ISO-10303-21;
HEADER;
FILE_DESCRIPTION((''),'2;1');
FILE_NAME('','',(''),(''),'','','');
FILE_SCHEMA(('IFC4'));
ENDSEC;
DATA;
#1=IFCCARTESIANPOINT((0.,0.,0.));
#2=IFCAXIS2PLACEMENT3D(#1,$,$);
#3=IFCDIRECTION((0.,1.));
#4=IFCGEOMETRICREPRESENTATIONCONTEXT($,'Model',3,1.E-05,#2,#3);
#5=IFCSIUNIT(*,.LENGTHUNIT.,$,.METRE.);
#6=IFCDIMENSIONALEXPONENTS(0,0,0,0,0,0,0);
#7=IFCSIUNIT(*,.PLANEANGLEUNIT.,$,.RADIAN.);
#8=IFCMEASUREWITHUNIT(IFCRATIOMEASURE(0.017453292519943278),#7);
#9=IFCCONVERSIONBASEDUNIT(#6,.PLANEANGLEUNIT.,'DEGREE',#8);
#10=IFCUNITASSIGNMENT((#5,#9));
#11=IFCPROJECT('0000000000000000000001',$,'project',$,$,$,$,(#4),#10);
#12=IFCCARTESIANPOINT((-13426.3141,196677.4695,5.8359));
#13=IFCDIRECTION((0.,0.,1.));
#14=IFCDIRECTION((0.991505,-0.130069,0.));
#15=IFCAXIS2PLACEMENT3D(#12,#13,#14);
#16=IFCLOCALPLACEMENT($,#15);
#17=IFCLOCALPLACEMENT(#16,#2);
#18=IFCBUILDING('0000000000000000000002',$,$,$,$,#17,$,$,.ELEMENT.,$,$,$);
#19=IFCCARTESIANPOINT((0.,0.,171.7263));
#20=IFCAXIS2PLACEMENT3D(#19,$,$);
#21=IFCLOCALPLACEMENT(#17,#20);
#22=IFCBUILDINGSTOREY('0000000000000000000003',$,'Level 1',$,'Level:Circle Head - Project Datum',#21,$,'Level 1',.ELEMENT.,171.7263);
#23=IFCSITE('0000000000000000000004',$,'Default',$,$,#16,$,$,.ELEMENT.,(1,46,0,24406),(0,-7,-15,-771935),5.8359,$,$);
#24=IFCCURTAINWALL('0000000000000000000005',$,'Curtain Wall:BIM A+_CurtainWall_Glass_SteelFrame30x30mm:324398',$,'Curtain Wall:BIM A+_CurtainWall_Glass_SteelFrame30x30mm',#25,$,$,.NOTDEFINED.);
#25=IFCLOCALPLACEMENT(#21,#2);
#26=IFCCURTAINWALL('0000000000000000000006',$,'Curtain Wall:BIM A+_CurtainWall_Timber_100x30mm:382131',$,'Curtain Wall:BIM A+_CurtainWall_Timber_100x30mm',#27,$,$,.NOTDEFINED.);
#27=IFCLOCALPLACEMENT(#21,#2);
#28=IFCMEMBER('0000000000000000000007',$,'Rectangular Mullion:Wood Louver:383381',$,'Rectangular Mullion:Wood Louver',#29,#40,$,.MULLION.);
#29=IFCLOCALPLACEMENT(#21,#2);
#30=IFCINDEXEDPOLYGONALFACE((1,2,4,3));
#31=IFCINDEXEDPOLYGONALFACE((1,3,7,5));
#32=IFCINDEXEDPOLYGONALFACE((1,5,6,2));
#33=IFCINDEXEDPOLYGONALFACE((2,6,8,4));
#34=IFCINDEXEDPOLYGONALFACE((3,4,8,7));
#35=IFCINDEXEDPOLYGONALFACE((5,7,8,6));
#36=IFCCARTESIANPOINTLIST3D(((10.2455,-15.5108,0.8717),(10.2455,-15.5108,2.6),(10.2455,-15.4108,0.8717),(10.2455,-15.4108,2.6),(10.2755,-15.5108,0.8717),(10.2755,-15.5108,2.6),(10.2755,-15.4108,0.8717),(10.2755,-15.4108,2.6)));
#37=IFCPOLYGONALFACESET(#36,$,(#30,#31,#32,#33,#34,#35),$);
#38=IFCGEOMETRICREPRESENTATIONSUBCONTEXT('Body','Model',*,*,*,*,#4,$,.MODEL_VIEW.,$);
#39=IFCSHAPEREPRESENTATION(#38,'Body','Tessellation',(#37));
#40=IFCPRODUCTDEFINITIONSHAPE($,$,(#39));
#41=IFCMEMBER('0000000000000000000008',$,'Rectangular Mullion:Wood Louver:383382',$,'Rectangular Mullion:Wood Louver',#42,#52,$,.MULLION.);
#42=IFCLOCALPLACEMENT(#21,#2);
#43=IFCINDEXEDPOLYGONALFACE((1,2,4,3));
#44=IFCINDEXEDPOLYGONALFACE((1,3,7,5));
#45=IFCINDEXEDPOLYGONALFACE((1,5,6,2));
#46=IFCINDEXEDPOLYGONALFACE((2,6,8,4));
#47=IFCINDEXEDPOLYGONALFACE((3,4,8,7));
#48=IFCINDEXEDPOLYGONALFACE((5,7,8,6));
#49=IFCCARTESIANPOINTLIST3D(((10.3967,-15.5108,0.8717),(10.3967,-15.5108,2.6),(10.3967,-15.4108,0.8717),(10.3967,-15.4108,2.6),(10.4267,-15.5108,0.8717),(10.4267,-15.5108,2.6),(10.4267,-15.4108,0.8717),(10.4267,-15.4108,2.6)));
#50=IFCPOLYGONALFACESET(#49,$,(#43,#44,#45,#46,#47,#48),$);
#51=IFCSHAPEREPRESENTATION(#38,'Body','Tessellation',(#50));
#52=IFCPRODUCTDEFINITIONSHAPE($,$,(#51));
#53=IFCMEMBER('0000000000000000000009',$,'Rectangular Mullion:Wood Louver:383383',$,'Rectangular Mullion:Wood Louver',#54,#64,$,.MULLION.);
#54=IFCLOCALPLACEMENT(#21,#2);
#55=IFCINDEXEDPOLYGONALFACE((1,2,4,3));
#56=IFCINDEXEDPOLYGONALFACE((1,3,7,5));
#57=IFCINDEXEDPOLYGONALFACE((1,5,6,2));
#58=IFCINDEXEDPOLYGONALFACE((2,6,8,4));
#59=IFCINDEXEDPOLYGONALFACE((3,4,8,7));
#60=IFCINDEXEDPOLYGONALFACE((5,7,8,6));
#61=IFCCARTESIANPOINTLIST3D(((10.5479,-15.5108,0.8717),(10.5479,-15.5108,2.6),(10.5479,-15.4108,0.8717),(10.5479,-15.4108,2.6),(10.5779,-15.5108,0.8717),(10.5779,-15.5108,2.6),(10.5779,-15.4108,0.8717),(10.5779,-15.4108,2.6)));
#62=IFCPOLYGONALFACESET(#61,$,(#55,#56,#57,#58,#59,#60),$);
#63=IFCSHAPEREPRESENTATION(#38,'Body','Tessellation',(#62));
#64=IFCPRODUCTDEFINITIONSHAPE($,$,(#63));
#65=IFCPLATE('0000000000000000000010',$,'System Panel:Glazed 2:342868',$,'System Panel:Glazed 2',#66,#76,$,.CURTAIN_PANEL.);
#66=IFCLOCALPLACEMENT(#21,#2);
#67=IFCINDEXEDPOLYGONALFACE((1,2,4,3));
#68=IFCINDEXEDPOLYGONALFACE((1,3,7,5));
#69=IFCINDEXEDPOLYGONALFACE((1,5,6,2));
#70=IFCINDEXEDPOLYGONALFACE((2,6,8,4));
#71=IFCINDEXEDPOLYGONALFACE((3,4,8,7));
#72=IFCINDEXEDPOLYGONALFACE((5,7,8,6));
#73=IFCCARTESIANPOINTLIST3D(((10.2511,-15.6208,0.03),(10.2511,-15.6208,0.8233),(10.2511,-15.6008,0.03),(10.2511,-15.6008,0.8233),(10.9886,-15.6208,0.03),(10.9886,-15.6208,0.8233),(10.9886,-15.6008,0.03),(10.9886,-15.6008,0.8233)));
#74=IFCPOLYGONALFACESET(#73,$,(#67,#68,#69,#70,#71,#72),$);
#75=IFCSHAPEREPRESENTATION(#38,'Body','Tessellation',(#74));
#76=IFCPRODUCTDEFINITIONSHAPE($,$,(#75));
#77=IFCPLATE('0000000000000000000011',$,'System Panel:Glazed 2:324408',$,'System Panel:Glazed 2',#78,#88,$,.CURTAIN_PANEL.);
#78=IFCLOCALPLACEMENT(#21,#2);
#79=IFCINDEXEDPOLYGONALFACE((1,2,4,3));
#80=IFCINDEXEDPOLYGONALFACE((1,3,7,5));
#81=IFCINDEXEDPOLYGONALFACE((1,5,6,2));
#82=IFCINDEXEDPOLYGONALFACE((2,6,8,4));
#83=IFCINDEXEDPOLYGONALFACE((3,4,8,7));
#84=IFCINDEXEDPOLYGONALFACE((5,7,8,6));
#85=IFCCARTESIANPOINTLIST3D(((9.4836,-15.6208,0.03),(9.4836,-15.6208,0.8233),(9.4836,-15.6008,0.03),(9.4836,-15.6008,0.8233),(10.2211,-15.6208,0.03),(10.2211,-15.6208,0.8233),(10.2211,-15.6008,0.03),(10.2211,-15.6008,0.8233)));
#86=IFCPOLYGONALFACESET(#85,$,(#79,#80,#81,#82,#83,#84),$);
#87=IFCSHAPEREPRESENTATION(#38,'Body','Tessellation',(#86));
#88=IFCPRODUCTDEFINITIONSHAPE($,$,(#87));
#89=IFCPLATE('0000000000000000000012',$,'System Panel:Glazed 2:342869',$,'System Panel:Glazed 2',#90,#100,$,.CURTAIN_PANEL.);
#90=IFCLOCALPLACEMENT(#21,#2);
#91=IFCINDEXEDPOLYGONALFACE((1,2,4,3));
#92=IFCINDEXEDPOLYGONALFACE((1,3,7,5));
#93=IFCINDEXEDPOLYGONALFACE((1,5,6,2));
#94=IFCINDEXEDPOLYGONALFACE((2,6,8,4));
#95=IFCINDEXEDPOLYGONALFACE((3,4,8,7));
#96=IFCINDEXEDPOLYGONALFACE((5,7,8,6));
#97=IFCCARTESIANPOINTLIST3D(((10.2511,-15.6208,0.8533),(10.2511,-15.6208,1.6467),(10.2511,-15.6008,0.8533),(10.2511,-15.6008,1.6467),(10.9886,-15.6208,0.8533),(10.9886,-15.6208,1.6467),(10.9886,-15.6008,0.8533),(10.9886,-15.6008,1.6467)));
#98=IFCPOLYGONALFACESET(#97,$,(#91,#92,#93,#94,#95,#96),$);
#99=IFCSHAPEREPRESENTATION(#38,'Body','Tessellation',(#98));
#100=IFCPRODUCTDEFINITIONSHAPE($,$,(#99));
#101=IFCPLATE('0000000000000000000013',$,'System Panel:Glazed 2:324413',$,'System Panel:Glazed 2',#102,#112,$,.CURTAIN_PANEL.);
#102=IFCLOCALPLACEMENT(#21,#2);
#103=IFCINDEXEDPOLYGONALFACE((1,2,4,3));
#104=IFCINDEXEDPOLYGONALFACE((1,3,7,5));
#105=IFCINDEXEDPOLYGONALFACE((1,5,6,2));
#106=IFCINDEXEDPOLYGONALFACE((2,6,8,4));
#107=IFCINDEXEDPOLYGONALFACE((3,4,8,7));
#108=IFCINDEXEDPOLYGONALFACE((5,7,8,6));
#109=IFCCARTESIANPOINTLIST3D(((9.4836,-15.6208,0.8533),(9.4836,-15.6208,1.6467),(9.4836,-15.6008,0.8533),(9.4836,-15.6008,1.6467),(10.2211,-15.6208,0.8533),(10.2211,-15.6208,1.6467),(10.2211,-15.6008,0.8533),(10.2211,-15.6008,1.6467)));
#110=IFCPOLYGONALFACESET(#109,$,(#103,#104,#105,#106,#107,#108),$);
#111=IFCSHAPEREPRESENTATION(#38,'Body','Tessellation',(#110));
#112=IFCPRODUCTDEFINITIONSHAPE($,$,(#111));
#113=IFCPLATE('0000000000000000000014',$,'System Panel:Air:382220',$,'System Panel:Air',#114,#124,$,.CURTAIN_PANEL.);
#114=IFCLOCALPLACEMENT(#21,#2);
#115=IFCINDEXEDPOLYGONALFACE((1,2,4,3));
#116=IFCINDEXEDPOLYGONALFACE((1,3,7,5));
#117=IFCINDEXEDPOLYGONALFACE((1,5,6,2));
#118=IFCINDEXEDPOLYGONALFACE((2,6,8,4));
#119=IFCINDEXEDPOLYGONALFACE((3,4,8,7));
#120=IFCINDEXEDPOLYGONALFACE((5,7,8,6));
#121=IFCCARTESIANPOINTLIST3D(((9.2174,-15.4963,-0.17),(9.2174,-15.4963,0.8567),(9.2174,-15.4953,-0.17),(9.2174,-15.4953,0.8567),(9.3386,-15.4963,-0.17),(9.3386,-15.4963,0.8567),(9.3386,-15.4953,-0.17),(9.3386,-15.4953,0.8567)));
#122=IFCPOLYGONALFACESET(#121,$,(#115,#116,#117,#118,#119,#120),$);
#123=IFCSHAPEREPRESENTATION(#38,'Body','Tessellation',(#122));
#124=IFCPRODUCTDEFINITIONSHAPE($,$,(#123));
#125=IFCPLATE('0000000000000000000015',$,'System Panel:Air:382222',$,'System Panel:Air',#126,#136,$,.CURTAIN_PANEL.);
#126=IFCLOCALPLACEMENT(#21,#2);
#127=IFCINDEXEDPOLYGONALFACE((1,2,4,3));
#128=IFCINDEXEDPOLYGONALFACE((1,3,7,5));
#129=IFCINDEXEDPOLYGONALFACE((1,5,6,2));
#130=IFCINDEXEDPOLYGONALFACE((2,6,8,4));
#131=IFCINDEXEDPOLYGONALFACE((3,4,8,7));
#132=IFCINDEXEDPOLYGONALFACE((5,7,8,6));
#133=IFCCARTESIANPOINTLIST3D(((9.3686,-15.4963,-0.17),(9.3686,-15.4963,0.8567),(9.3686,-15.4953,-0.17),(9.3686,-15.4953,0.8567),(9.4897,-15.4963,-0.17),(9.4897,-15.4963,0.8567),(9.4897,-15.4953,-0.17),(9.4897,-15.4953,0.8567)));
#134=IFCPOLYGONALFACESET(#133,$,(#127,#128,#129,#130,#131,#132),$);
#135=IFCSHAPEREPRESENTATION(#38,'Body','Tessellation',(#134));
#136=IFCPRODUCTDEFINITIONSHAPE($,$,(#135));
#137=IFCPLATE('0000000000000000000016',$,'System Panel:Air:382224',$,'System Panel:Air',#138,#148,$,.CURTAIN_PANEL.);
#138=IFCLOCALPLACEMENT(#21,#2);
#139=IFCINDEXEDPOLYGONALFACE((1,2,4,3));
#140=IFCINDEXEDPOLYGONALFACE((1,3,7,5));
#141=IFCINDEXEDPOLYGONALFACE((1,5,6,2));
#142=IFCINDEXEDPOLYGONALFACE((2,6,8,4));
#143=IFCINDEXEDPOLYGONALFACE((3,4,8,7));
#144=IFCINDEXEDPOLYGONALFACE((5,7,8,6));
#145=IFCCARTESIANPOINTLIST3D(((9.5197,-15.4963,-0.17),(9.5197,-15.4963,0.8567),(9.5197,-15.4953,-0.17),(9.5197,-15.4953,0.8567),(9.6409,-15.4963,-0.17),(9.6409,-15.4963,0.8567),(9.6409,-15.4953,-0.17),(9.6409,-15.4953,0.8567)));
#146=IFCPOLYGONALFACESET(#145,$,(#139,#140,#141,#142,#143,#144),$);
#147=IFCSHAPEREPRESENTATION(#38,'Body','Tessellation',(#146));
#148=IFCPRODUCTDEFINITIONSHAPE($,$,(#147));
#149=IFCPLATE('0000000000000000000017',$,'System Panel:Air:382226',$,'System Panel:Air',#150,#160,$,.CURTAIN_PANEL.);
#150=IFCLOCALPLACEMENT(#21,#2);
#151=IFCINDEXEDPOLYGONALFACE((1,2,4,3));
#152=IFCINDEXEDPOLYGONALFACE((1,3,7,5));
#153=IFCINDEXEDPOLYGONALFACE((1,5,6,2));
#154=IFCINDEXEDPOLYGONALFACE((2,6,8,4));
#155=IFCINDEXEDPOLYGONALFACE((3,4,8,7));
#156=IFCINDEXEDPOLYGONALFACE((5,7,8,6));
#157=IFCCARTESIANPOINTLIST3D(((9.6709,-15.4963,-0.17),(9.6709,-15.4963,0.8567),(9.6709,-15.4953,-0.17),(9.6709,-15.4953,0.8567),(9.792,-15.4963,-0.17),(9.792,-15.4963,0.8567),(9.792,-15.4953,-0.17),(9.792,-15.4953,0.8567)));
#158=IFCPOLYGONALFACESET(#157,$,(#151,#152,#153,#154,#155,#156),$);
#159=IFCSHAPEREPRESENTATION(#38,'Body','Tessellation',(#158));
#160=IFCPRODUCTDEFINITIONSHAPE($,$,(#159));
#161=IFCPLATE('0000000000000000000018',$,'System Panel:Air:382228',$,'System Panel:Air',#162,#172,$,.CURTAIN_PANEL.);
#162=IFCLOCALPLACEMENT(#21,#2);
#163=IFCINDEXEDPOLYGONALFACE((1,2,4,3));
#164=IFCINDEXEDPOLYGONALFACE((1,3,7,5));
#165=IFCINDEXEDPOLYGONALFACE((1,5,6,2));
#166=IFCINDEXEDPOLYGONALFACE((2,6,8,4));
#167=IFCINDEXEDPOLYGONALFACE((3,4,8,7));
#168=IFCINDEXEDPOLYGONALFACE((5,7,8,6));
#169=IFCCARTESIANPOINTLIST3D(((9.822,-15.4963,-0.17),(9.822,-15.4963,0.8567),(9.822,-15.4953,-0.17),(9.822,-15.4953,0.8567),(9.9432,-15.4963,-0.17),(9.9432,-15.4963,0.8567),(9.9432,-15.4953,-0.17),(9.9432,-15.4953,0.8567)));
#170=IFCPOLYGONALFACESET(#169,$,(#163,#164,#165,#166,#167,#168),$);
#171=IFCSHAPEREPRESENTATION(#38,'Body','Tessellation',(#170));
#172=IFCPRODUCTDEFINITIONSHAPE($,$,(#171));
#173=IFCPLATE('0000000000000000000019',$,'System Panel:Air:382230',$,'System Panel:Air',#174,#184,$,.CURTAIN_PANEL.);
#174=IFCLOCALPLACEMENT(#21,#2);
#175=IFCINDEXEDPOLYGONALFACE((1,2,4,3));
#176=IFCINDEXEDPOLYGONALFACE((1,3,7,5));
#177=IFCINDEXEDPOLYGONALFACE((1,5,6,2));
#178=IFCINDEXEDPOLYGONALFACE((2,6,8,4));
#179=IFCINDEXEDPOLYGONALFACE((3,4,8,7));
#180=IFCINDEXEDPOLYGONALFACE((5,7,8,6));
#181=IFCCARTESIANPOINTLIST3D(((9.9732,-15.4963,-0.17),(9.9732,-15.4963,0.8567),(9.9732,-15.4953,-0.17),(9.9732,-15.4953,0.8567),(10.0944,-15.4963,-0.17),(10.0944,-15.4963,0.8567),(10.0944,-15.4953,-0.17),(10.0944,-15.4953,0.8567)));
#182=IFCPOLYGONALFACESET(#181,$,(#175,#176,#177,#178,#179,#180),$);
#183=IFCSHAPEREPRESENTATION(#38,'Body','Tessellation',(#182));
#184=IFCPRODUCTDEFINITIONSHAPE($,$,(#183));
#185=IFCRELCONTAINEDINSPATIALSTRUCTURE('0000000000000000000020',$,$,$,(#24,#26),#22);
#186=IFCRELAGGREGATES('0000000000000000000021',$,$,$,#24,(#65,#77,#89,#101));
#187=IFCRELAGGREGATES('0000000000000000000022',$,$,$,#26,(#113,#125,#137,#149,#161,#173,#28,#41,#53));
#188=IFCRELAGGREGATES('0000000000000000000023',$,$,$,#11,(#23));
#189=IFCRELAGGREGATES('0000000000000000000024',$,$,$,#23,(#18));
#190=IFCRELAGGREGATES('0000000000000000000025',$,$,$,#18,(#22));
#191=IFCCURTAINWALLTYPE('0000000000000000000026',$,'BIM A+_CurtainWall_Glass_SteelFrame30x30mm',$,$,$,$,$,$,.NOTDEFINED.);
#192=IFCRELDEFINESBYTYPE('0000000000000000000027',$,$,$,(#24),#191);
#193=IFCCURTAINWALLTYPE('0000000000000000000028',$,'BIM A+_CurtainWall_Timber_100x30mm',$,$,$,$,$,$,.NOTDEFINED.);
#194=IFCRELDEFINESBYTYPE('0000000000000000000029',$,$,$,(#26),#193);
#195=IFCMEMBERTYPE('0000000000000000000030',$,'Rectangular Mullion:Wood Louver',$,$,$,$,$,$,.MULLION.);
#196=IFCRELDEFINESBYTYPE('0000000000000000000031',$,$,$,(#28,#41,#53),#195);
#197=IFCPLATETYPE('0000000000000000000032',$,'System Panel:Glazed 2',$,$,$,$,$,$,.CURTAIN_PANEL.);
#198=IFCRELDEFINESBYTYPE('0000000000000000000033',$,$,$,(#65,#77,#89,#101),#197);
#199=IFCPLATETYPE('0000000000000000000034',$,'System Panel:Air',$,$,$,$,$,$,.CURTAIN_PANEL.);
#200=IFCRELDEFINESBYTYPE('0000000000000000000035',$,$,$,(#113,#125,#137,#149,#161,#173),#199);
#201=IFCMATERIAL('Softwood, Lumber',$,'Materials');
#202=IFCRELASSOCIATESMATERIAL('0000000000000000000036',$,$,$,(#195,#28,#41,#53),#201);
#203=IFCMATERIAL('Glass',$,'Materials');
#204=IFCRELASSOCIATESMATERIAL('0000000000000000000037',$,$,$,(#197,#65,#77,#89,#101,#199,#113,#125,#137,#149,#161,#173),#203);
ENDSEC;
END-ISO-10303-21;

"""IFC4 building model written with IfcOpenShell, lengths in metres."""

from ifc_helpers import new_model, entity, si_unit, converted_unit, direction, frame, origin, place, context, subcontext, project, spatial, indexed_curve, outline, extrude, source, transform, mapped, material, type_object, type_shapes, element, aggregate, save


model = new_model("IFC4")

# Units and contexts
model_context = context("Model", 3, precision=1e-05, world=origin(), true_north=direction((0.0, 1.0)))
body_context = subcontext(model_context, "Body", "Model", "MODEL_VIEW")
ifc_project = project(units=[si_unit("LENGTHUNIT", "METRE"), converted_unit("PLANEANGLEUNIT", "DEGREE", entity("IfcRatioMeasure", 0.017453292519943278), si_unit("PLANEANGLEUNIT", "RADIAN"), dimensions=[0, 0, 0, 0, 0, 0, 0])], contexts=[model_context])

# Site, building, storey
site_placement = place(None, frame((-13426.3141, 196677.4695, 5.8359), z_axis=(0.0, 0.0, 1.0), x_axis=(0.991505, -0.130069, 0.0)))
site = spatial("IfcSite", under=ifc_project, at=site_placement, Name="Default", CompositionType="ELEMENT", RefLatitude=(1, 46, 0, 24406), RefLongitude=(0, -7, -15, -771935), RefElevation=5.8359)
building_placement = place(site_placement, origin())
building = spatial("IfcBuilding", under=site, at=building_placement, CompositionType="ELEMENT")
storey_placement = place(building_placement, frame((0.0, 0.0, 171.7263)))
storey = spatial("IfcBuildingStorey", under=building, at=storey_placement, Name="Level 1", ObjectType="Level:Circle Head - Project Datum", LongName="Level 1", CompositionType="ELEMENT", Elevation=171.7263)

# Curtain wall
curtain_wall_type_1 = type_object("IfcCurtainWallType", Name="BIM A+_CurtainWall_Glass_SteelFrame30x30mm", PredefinedType="NOTDEFINED")
curtain_wall_1_placement = place(storey_placement, frame((0.0, 0.0, -171.7263)))
curtain_wall_1 = element("IfcCurtainWall", 1, at=curtain_wall_1_placement, inside=storey, type_object=curtain_wall_type_1, Name="Curtain Wall:BIM A+_CurtainWall_Glass_SteelFrame30x30mm:324398", ObjectType="Curtain Wall:BIM A+_CurtainWall_Glass_SteelFrame30x30mm", PredefinedType="NOTDEFINED")

# Curtain wall, members
curtain_wall_type_2 = type_object("IfcCurtainWallType", Name="BIM A+_CurtainWall_Timber_100x30mm", PredefinedType="NOTDEFINED")
curtain_wall_2_placement = place(storey_placement, frame((0.0, 0.0, -171.7263)))
curtain_wall_2 = element("IfcCurtainWall", 2, at=curtain_wall_2_placement, inside=storey, type_object=curtain_wall_type_2, Name="Curtain Wall:BIM A+_CurtainWall_Timber_100x30mm:382131", ObjectType="Curtain Wall:BIM A+_CurtainWall_Timber_100x30mm", PredefinedType="NOTDEFINED")
ifc_material_1 = material(Name="Softwood, Lumber", Category="Materials")
member_type_1 = type_object("IfcMemberType", Name="Rectangular Mullion:Wood Louver", PredefinedType="MULLION", material=ifc_material_1)
shared_shape_1 = source(origin(), body_context, "Body", "SweptSolid", [
    extrude(outline(indexed_curve([(-0.05, -0.015), (0.05, -0.015), (0.05, 0.015), (-0.05, 0.015), (-0.05, -0.015)], self_intersect=False)), frame((0.0, -0.035, -1.7283), z_axis=(0.0, 0.0, 1.0), x_axis=(0.0, -1.0, 0.0)), (0.0, 0.0, 1.0), 1.7283),
])
type_shapes(member_type_1, [shared_shape_1])
member_1_placement = place(curtain_wall_2_placement, frame((10.2605, -15.4958, 172.598), z_axis=(0.0, 0.0, -1.0), x_axis=(1.0, 0.0, 0.0)))
member_1 = element("IfcMember", 3, at=member_1_placement, type_object=member_type_1, material=ifc_material_1, Name="Rectangular Mullion:Wood Louver:383381", ObjectType="Rectangular Mullion:Wood Louver", PredefinedType="MULLION", context=body_context, shape_type="MappedRepresentation", body=[
    mapped(shared_shape_1, transform((0.0, 0.0, 0.0), scale=1.0)),
])
member_2_placement = place(curtain_wall_2_placement, frame((10.4117, -15.4958, 172.598), z_axis=(0.0, 0.0, -1.0), x_axis=(1.0, 0.0, 0.0)))
member_2 = element("IfcMember", 4, at=member_2_placement, type_object=member_type_1, material=ifc_material_1, Name="Rectangular Mullion:Wood Louver:383382", ObjectType="Rectangular Mullion:Wood Louver", PredefinedType="MULLION", context=body_context, shape_type="MappedRepresentation", body=[
    mapped(shared_shape_1, transform((0.0, 0.0, 0.0), scale=1.0)),
])
member_3_placement = place(curtain_wall_2_placement, frame((10.5629, -15.4958, 172.598), z_axis=(0.0, 0.0, -1.0), x_axis=(1.0, 0.0, 0.0)))
member_3 = element("IfcMember", 5, at=member_3_placement, type_object=member_type_1, material=ifc_material_1, Name="Rectangular Mullion:Wood Louver:383383", ObjectType="Rectangular Mullion:Wood Louver", PredefinedType="MULLION", context=body_context, shape_type="MappedRepresentation", body=[
    mapped(shared_shape_1, transform((0.0, 0.0, 0.0), scale=1.0)),
])

# Plates
ifc_material_2 = material(Name="Glass", Category="Materials")
plate_type_1 = type_object("IfcPlateType", Name="System Panel:Glazed 2", PredefinedType="CURTAIN_PANEL", material=ifc_material_2)
shared_shape_2 = source(origin(), body_context, "Body", "SweptSolid", [
    extrude(outline(indexed_curve([(-0.01, -0.3688), (0.01, -0.3688), (0.01, 0.3688), (-0.01, 0.3688), (-0.01, -0.3688)], self_intersect=False)), frame((0.0, 0.0, 0.0), z_axis=(0.0, 0.0, 1.0), x_axis=(0.0, 1.0, 0.0)), (0.0, 0.0, 1.0), 0.7933),
])
type_shapes(plate_type_1, [shared_shape_2])
plate_1_placement = place(curtain_wall_1_placement, frame((10.6198, -15.6108, 171.7563), z_axis=(0.0, 0.0, 1.0), x_axis=(-1.0, 0.0, 0.0)))
plate_1 = element("IfcPlate", 6, at=plate_1_placement, type_object=plate_type_1, material=ifc_material_2, Name="System Panel:Glazed 2:342868", ObjectType="System Panel:Glazed 2", PredefinedType="CURTAIN_PANEL", context=body_context, shape_type="MappedRepresentation", body=[
    mapped(shared_shape_2, transform((0.0, 0.0, 0.0), scale=1.0)),
])
plate_2_placement = place(curtain_wall_1_placement, frame((9.8523, -15.6108, 171.7563), z_axis=(0.0, 0.0, 1.0), x_axis=(-1.0, 0.0, 0.0)))
plate_2 = element("IfcPlate", 7, at=plate_2_placement, type_object=plate_type_1, material=ifc_material_2, Name="System Panel:Glazed 2:324408", ObjectType="System Panel:Glazed 2", PredefinedType="CURTAIN_PANEL", context=body_context, shape_type="MappedRepresentation", body=[
    mapped(shared_shape_2, transform((0.0, 0.0, 0.0), scale=1.0)),
])
plate_3_placement = place(curtain_wall_1_placement, frame((10.6198, -15.6108, 172.5796), z_axis=(0.0, 0.0, 1.0), x_axis=(-1.0, 0.0, 0.0)))
plate_3 = element("IfcPlate", 8, at=plate_3_placement, type_object=plate_type_1, material=ifc_material_2, Name="System Panel:Glazed 2:342869", ObjectType="System Panel:Glazed 2", PredefinedType="CURTAIN_PANEL", context=body_context, shape_type="MappedRepresentation", body=[
    mapped(shared_shape_2, transform((0.0, 0.0, 0.0), scale=1.0)),
])
plate_4_placement = place(curtain_wall_1_placement, frame((9.8523, -15.6108, 172.5796), z_axis=(0.0, 0.0, 1.0), x_axis=(-1.0, 0.0, 0.0)))
plate_4 = element("IfcPlate", 9, at=plate_4_placement, type_object=plate_type_1, material=ifc_material_2, Name="System Panel:Glazed 2:324413", ObjectType="System Panel:Glazed 2", PredefinedType="CURTAIN_PANEL", context=body_context, shape_type="MappedRepresentation", body=[
    mapped(shared_shape_2, transform((0.0, 0.0, 0.0), scale=1.0)),
])
aggregate(curtain_wall_1, [plate_1, plate_2, plate_3, plate_4])
plate_type_2 = type_object("IfcPlateType", Name="System Panel:Air", PredefinedType="CURTAIN_PANEL", material=ifc_material_2)
shared_shape_3 = source(origin(), body_context, "Body", "SweptSolid", [
    extrude(outline(indexed_curve([(-0.0005, -0.0606), (0.0005, -0.0606), (0.0005, 0.0606), (-0.0005, 0.0606), (-0.0005, -0.0606)], self_intersect=False)), frame((0.0, 0.0, 0.0), z_axis=(0.0, 0.0, 1.0), x_axis=(0.0, 1.0, 0.0)), (0.0, 0.0, 1.0), 1.0267),
])
type_shapes(plate_type_2, [shared_shape_3])
plate_5_placement = place(curtain_wall_2_placement, frame((9.278, -15.4958, 171.5563)))
plate_5 = element("IfcPlate", 10, at=plate_5_placement, type_object=plate_type_2, material=ifc_material_2, Name="System Panel:Air:382220", ObjectType="System Panel:Air", PredefinedType="CURTAIN_PANEL", context=body_context, shape_type="MappedRepresentation", body=[
    mapped(shared_shape_3, transform((0.0, 0.0, 0.0), scale=1.0)),
])
plate_6_placement = place(curtain_wall_2_placement, frame((9.4291, -15.4958, 171.5563)))
plate_6 = element("IfcPlate", 11, at=plate_6_placement, type_object=plate_type_2, material=ifc_material_2, Name="System Panel:Air:382222", ObjectType="System Panel:Air", PredefinedType="CURTAIN_PANEL", context=body_context, shape_type="MappedRepresentation", body=[
    mapped(shared_shape_3, transform((0.0, 0.0, 0.0), scale=1.0)),
])
plate_7_placement = place(curtain_wall_2_placement, frame((9.5803, -15.4958, 171.5563)))
plate_7 = element("IfcPlate", 12, at=plate_7_placement, type_object=plate_type_2, material=ifc_material_2, Name="System Panel:Air:382224", ObjectType="System Panel:Air", PredefinedType="CURTAIN_PANEL", context=body_context, shape_type="MappedRepresentation", body=[
    mapped(shared_shape_3, transform((0.0, 0.0, 0.0), scale=1.0)),
])
plate_8_placement = place(curtain_wall_2_placement, frame((9.7315, -15.4958, 171.5563)))
plate_8 = element("IfcPlate", 13, at=plate_8_placement, type_object=plate_type_2, material=ifc_material_2, Name="System Panel:Air:382226", ObjectType="System Panel:Air", PredefinedType="CURTAIN_PANEL", context=body_context, shape_type="MappedRepresentation", body=[
    mapped(shared_shape_3, transform((0.0, 0.0, 0.0), scale=1.0)),
])
plate_9_placement = place(curtain_wall_2_placement, frame((9.8826, -15.4958, 171.5563)))
plate_9 = element("IfcPlate", 14, at=plate_9_placement, type_object=plate_type_2, material=ifc_material_2, Name="System Panel:Air:382228", ObjectType="System Panel:Air", PredefinedType="CURTAIN_PANEL", context=body_context, shape_type="MappedRepresentation", body=[
    mapped(shared_shape_3, transform((0.0, 0.0, 0.0), scale=1.0)),
])
plate_10_placement = place(curtain_wall_2_placement, frame((10.0338, -15.4958, 171.5563)))
plate_10 = element("IfcPlate", 15, at=plate_10_placement, type_object=plate_type_2, material=ifc_material_2, Name="System Panel:Air:382230", ObjectType="System Panel:Air", PredefinedType="CURTAIN_PANEL", context=body_context, shape_type="MappedRepresentation", body=[
    mapped(shared_shape_3, transform((0.0, 0.0, 0.0), scale=1.0)),
])
aggregate(curtain_wall_2, [plate_5, plate_6, plate_7, plate_8, plate_9, plate_10, member_1, member_2, member_3])

save(model, "model.ifc")
